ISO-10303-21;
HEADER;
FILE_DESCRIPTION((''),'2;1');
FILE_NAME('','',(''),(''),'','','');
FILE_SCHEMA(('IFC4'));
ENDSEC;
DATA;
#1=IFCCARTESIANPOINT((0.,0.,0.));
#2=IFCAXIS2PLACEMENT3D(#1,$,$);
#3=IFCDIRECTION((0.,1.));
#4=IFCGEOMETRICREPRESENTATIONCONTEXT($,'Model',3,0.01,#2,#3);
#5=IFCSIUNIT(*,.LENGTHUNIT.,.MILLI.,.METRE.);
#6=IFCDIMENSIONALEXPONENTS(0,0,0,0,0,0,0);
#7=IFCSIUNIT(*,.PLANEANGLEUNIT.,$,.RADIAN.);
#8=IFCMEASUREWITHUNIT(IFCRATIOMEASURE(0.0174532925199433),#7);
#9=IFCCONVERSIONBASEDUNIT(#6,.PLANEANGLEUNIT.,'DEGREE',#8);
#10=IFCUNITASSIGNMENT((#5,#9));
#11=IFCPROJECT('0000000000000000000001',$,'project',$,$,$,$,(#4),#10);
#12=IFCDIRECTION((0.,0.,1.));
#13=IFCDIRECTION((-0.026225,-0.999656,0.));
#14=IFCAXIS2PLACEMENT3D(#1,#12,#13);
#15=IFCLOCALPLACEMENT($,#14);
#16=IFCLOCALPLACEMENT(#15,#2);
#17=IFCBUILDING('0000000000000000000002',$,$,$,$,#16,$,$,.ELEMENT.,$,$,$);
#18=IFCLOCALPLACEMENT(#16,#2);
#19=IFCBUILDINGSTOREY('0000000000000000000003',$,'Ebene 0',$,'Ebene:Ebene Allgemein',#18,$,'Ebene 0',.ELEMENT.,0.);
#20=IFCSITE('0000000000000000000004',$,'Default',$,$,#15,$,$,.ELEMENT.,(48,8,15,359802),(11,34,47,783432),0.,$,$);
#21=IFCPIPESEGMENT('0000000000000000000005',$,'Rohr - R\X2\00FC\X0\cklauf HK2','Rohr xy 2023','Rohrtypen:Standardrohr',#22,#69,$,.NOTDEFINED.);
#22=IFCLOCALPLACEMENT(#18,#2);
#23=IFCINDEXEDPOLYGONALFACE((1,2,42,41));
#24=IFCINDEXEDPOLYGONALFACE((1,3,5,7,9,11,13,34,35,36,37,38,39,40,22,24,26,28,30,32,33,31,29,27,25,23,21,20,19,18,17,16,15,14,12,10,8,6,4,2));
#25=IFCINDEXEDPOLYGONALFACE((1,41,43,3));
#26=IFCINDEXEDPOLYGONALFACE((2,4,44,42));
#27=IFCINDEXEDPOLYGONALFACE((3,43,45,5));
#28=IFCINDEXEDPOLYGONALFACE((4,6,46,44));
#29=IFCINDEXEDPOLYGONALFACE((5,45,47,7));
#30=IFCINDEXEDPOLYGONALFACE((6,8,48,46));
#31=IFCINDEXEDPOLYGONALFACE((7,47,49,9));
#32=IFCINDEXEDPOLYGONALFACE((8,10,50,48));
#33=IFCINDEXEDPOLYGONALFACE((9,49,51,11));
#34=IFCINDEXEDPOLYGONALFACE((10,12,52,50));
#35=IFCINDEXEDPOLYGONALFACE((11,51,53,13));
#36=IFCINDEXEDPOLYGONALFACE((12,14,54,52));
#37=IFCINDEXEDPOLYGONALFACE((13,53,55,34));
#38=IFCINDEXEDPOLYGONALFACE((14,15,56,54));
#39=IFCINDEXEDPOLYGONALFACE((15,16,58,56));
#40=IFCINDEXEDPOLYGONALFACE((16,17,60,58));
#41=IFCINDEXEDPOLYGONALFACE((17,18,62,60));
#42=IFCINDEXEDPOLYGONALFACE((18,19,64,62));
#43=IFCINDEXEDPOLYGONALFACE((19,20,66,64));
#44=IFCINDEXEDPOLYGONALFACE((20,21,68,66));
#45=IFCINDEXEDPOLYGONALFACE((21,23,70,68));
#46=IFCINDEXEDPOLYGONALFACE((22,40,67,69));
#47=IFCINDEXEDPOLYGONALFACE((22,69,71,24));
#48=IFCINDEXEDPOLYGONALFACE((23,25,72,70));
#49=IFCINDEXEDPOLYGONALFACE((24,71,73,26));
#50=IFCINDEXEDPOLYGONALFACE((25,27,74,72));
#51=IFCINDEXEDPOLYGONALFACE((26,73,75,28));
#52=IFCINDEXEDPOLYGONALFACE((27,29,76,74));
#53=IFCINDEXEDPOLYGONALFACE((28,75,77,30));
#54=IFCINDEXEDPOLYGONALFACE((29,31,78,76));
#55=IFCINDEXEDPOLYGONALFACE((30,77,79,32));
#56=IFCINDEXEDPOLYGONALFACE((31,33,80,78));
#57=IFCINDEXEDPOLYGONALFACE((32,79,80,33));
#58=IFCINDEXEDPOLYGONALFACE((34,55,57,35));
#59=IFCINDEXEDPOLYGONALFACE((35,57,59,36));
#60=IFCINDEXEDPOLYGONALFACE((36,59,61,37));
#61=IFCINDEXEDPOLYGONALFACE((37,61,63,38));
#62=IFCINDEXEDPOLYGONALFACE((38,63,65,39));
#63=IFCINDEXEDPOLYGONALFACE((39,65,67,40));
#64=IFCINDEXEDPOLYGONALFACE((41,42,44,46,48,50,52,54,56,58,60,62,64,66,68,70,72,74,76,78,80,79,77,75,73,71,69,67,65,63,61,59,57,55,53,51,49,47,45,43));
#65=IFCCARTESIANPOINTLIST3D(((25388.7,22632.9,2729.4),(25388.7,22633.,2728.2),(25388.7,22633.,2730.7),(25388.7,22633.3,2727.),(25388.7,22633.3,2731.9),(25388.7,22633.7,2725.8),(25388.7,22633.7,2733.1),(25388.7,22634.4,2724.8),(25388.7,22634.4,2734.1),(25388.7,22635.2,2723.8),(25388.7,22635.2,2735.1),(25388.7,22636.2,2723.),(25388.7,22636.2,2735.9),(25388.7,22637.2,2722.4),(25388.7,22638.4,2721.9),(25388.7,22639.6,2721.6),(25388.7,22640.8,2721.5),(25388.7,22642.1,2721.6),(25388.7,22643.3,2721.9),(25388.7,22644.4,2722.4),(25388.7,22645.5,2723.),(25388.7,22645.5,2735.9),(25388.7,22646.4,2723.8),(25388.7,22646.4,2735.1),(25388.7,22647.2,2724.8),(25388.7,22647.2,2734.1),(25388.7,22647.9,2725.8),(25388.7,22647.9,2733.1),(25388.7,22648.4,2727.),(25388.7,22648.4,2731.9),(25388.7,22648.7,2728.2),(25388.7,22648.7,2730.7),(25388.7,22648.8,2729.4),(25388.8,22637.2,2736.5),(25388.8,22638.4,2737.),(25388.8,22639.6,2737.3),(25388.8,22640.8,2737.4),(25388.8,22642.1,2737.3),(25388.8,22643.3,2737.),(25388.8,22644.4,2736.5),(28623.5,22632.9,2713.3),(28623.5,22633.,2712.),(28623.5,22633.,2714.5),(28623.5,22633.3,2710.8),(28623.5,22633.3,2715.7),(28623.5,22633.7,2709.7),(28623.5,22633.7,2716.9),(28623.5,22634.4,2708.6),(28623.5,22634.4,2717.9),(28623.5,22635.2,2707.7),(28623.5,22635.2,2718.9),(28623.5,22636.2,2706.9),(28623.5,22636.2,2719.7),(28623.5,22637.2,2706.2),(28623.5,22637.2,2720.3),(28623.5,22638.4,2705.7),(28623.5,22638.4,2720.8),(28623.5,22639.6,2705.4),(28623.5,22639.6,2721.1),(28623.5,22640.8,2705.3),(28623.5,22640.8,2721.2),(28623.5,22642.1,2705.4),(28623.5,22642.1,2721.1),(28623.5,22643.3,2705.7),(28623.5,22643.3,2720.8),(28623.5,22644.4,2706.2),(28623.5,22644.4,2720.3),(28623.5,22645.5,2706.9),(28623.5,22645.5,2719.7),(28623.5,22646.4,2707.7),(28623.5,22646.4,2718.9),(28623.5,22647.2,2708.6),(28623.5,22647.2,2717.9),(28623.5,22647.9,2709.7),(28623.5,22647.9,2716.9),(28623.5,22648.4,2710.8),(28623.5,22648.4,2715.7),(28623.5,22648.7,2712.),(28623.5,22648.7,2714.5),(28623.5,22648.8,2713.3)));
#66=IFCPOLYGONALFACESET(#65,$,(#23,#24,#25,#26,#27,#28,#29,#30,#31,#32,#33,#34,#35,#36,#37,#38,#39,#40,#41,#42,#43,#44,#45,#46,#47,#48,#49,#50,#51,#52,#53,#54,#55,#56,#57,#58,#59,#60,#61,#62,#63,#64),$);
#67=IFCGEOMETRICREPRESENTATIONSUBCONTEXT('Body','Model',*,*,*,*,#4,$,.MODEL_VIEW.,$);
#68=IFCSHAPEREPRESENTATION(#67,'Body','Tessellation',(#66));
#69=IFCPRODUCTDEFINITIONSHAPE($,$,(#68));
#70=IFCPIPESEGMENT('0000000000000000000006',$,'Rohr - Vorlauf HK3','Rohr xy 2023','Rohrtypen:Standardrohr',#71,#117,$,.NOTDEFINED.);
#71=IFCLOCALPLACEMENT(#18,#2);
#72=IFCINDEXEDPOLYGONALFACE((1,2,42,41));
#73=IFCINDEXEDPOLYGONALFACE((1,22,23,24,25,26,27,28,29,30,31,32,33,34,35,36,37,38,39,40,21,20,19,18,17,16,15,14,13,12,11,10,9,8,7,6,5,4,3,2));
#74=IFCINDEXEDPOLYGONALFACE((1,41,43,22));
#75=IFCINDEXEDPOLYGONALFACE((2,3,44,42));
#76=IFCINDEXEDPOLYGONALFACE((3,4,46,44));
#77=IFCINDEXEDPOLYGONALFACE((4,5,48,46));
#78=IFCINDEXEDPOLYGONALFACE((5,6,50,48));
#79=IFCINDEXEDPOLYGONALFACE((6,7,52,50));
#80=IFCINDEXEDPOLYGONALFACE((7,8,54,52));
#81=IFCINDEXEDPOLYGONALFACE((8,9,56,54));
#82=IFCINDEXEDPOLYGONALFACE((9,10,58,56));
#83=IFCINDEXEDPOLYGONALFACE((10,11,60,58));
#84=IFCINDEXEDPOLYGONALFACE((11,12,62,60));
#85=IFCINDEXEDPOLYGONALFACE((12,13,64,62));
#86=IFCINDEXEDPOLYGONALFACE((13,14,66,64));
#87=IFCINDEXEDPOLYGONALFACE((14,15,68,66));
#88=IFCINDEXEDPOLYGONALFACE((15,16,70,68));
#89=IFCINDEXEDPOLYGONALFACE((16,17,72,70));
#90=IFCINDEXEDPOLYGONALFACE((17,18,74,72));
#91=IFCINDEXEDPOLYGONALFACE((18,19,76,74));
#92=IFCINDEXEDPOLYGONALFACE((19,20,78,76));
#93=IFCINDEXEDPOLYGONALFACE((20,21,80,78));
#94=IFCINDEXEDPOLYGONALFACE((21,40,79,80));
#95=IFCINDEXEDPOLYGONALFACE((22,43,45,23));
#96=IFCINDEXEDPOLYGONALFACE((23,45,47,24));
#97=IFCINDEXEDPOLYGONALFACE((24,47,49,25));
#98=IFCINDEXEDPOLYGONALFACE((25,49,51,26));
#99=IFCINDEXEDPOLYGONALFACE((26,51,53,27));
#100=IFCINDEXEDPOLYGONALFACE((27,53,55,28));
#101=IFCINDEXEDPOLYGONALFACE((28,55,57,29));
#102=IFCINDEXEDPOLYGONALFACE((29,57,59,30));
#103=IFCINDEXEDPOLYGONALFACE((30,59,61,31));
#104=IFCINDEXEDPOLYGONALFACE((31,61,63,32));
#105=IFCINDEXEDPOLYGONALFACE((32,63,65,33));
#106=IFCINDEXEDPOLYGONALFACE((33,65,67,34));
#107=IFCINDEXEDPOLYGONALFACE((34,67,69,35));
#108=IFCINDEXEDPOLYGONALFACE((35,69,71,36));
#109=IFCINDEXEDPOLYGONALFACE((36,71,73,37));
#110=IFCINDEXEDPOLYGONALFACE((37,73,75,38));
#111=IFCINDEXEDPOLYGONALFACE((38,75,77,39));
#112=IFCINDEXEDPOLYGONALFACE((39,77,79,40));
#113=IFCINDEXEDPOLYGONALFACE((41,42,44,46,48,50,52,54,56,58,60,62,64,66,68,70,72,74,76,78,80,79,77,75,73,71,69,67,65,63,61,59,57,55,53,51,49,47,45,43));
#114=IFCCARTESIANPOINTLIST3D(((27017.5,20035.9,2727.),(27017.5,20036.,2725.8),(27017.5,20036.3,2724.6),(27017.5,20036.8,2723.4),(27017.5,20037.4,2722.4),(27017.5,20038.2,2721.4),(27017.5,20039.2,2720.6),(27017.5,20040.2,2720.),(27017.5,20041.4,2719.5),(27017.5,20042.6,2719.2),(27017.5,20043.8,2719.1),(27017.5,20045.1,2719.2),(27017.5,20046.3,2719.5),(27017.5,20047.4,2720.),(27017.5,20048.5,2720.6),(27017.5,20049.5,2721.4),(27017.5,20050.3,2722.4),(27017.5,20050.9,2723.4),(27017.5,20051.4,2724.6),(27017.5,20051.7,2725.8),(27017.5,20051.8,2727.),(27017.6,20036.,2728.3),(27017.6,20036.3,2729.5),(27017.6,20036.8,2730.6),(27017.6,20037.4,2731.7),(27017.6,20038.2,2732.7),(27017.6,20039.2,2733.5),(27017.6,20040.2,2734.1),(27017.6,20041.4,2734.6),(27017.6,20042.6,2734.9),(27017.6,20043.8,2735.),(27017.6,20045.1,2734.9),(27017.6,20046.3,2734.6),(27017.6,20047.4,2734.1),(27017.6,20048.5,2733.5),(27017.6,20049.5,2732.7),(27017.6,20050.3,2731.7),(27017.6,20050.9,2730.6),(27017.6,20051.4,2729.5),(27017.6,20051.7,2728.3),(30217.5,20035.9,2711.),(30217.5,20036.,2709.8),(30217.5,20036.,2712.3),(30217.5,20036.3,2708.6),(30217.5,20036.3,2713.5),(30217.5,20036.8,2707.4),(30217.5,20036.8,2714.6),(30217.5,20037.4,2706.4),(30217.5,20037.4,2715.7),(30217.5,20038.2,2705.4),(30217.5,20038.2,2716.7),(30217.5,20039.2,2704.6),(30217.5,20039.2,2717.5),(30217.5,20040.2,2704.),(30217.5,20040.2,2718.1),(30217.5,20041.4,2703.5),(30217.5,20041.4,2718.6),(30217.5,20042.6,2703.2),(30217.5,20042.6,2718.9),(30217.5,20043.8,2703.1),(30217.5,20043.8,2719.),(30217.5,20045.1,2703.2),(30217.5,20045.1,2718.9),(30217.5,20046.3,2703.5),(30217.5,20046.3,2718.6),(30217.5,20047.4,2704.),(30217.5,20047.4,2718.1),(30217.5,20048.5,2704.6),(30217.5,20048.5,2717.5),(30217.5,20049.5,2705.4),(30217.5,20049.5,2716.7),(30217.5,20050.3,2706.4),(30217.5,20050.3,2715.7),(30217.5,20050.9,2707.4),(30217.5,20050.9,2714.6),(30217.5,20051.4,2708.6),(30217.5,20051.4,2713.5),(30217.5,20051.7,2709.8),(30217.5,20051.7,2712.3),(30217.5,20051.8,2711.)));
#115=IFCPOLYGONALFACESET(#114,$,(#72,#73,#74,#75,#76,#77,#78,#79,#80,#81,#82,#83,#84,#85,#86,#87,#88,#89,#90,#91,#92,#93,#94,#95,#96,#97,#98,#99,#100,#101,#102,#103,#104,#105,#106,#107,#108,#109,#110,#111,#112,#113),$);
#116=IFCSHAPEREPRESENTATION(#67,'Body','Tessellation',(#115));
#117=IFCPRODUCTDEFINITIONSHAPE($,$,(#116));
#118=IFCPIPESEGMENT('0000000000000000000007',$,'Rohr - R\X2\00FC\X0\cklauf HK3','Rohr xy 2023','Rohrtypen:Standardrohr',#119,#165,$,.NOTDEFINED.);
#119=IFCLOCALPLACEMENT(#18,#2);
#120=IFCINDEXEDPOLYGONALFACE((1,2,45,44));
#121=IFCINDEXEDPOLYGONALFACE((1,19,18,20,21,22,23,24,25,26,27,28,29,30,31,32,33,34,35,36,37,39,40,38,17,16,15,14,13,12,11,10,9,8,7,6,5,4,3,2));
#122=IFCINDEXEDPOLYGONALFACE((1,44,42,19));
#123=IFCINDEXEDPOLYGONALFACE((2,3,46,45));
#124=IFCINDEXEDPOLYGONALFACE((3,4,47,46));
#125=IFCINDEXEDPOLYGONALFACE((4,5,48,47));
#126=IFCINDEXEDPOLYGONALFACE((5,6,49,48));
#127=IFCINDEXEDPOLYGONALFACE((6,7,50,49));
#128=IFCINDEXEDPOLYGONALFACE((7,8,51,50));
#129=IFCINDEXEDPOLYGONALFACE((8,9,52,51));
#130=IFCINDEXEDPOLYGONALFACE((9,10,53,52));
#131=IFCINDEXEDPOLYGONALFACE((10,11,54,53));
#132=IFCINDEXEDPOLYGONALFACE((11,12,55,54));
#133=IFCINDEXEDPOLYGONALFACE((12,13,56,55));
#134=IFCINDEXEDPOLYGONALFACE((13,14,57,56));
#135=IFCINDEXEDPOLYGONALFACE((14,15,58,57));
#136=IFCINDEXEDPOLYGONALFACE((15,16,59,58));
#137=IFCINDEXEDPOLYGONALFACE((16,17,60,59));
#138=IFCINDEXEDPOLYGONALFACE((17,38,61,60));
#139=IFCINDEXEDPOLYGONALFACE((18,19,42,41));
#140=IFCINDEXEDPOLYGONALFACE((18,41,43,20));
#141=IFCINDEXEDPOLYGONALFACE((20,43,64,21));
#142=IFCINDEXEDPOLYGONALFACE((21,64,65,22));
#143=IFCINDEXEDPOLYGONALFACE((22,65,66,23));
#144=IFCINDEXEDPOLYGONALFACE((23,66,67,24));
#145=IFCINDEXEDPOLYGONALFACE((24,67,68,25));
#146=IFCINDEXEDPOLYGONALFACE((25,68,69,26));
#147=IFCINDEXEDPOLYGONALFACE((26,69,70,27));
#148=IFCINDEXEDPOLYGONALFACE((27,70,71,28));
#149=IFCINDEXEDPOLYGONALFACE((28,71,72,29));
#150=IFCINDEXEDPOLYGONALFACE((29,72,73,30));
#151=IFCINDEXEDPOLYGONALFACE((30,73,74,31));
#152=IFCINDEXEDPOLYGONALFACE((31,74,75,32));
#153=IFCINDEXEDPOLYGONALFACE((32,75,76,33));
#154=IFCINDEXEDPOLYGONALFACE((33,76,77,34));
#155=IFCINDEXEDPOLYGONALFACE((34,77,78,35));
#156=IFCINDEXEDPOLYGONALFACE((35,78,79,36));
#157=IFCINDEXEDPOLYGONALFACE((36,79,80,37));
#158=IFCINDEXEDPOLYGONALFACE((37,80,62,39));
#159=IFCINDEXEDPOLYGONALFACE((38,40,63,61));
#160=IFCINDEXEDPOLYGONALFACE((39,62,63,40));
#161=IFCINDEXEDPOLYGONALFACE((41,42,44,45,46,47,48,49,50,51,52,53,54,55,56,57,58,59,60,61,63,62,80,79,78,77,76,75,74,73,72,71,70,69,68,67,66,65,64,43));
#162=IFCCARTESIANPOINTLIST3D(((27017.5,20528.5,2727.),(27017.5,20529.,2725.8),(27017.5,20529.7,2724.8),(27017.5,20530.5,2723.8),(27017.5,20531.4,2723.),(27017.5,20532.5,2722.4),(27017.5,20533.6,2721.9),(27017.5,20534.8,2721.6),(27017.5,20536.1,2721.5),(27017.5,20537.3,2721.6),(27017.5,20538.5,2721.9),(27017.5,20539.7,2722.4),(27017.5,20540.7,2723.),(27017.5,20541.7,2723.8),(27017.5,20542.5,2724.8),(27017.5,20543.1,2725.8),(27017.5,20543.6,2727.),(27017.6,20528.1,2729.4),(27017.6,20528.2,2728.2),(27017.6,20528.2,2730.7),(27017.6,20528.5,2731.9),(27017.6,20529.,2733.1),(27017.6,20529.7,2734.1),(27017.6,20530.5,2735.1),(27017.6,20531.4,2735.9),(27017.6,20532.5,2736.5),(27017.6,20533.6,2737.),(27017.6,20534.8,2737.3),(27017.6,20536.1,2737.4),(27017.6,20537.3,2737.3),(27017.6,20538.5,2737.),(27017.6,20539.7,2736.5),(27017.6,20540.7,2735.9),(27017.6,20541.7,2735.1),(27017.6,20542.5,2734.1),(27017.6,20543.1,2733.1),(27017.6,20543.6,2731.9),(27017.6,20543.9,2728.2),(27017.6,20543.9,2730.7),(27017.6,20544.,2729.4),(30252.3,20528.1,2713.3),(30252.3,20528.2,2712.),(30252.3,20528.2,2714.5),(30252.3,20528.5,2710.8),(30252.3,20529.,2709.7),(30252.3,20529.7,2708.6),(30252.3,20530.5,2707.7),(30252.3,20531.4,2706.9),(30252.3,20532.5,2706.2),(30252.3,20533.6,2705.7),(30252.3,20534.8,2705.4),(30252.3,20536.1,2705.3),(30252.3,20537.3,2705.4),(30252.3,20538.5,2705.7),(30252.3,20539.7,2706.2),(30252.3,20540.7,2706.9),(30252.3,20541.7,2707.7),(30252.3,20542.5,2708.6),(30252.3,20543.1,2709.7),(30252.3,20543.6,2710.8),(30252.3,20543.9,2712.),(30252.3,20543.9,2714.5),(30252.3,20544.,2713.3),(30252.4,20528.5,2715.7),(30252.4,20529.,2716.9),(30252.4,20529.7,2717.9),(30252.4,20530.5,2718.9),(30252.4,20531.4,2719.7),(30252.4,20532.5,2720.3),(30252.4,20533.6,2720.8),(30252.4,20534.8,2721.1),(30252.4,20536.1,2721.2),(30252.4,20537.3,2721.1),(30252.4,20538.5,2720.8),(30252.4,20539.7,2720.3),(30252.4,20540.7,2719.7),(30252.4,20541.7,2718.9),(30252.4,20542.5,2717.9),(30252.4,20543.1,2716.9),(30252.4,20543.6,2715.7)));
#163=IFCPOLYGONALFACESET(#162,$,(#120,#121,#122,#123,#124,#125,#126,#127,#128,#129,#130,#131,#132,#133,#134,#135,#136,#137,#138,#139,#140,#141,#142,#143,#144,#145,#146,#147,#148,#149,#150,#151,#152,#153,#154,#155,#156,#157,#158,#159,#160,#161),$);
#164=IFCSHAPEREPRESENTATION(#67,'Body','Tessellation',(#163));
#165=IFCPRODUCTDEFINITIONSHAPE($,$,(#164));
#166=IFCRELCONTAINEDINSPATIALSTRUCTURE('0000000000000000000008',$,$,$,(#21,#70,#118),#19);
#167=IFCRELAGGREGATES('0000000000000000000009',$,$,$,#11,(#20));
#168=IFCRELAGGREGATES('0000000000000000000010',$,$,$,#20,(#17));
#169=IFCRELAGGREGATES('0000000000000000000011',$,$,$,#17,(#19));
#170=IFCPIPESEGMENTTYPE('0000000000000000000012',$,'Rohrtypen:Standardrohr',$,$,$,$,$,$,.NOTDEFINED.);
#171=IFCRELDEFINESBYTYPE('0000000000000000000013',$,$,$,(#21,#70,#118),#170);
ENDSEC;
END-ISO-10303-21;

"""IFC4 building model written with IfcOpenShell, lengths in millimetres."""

from ifc_helpers import new_model, entity, si_unit, converted_unit, direction, frame, origin, place, context, subcontext, project, spatial, indexed_curve, outline, extrude, type_object, element, save


model = new_model("IFC4")

# Units and contexts
model_context = context("Model", 3, precision=0.01, world=origin(), true_north=direction((0.0, 1.0)))
body_context = subcontext(model_context, "Body", "Model", "MODEL_VIEW")
ifc_project = project(units=[si_unit("LENGTHUNIT", "METRE", prefix="MILLI"), converted_unit("PLANEANGLEUNIT", "DEGREE", entity("IfcRatioMeasure", 0.0174532925199433), si_unit("PLANEANGLEUNIT", "RADIAN"), dimensions=[0, 0, 0, 0, 0, 0, 0])], contexts=[model_context])

# Site, building, storey
site_placement = place(None, frame((0.0, 0.0, 0.0), z_axis=(0.0, 0.0, 1.0), x_axis=(-0.026225, -0.999656, 0.0)))
site = spatial("IfcSite", under=ifc_project, at=site_placement, Name="Default", CompositionType="ELEMENT", RefLatitude=(48, 8, 15, 359802), RefLongitude=(11, 34, 47, 783432), RefElevation=0.0)
building_placement = place(site_placement, origin())
building = spatial("IfcBuilding", under=site, at=building_placement, CompositionType="ELEMENT")
storey_placement = place(building_placement, origin())
storey = spatial("IfcBuildingStorey", under=building, at=storey_placement, Name="Ebene 0", ObjectType="Ebene:Ebene Allgemein", LongName="Ebene 0", CompositionType="ELEMENT", Elevation=0.0)

# Pipe segments
pipe_segment_type = type_object("IfcPipeSegmentType", Name="Rohrtypen:Standardrohr", PredefinedType="NOTDEFINED")
pipe_segment_1_placement = place(storey_placement, origin())
element("IfcPipeSegment", 1, at=pipe_segment_1_placement, inside=storey, type_object=pipe_segment_type, Name="Rohr - Rücklauf HK2", Description="Rohr xy 2023", ObjectType="Rohrtypen:Standardrohr", PredefinedType="NOTDEFINED", context=body_context, shape_type="SweptSolid", body=[
    extrude(outline(indexed_curve([(7.9, 0.0), (7.8, 1.2), (7.6, 2.5), (7.1, 3.6), (6.4, 4.7), (5.6, 5.6), (4.7, 6.4), (3.6, 7.1), (2.5, 7.6), (1.2, 7.8), (0.0, 7.9), (-1.2, 7.8), (-2.5, 7.6), (-3.6, 7.1), (-4.7, 6.4), (-5.6, 5.6), (-6.4, 4.7), (-7.1, 3.6), (-7.6, 2.5), (-7.8, 1.2), (-7.9, 0.0), (-7.8, -1.2), (-7.6, -2.5), (-7.1, -3.6), (-6.4, -4.7), (-5.6, -5.6), (-4.7, -6.4), (-3.6, -7.1), (-2.5, -7.6), (-1.2, -7.8), (0.0, -7.9), (1.2, -7.8), (2.5, -7.6), (3.6, -7.1), (4.7, -6.4), (5.6, -5.6), (6.4, -4.7), (7.1, -3.6), (7.6, -2.5), (7.8, -1.2), (7.9, 0.0)], self_intersect=False)), frame((28623.5, 22640.8, 2713.3), z_axis=(-0.999988, 0.0, 0.005), x_axis=(0.0, 1.0, 0.0)), (0.0, 0.0, 1.0), 3234.8),
])
pipe_segment_2_placement = place(storey_placement, origin())
element("IfcPipeSegment", 2, at=pipe_segment_2_placement, inside=storey, type_object=pipe_segment_type, Name="Rohr - Vorlauf HK3", Description="Rohr xy 2023", ObjectType="Rohrtypen:Standardrohr", PredefinedType="NOTDEFINED", context=body_context, shape_type="SweptSolid", body=[
    extrude(outline(indexed_curve([(7.9, 0.0), (7.8, 1.2), (7.6, 2.5), (7.1, 3.6), (6.4, 4.7), (5.6, 5.6), (4.7, 6.4), (3.6, 7.1), (2.5, 7.6), (1.2, 7.8), (0.0, 7.9), (-1.2, 7.8), (-2.5, 7.6), (-3.6, 7.1), (-4.7, 6.4), (-5.6, 5.6), (-6.4, 4.7), (-7.1, 3.6), (-7.6, 2.5), (-7.8, 1.2), (-7.9, 0.0), (-7.8, -1.2), (-7.6, -2.5), (-7.1, -3.6), (-6.4, -4.7), (-5.6, -5.6), (-4.7, -6.4), (-3.6, -7.1), (-2.5, -7.6), (-1.2, -7.8), (0.0, -7.9), (1.2, -7.8), (2.5, -7.6), (3.6, -7.1), (4.7, -6.4), (5.6, -5.6), (6.4, -4.7), (7.1, -3.6), (7.6, -2.5), (7.8, -1.2), (7.9, 0.0)], self_intersect=False)), frame((30217.5, 20043.8, 2711.0), z_axis=(-0.999988, 0.0, 0.005), x_axis=(0.0, 1.0, 0.0)), (0.0, 0.0, 1.0), 3200.0),
])
pipe_segment_3_placement = place(storey_placement, origin())
element("IfcPipeSegment", 3, at=pipe_segment_3_placement, inside=storey, type_object=pipe_segment_type, Name="Rohr - Rücklauf HK3", Description="Rohr xy 2023", ObjectType="Rohrtypen:Standardrohr", PredefinedType="NOTDEFINED", context=body_context, shape_type="SweptSolid", body=[
    extrude(outline(indexed_curve([(7.9, 0.0), (7.8, 1.2), (7.6, 2.5), (7.1, 3.6), (6.4, 4.7), (5.6, 5.6), (4.7, 6.4), (3.6, 7.1), (2.5, 7.6), (1.2, 7.8), (0.0, 7.9), (-1.2, 7.8), (-2.5, 7.6), (-3.6, 7.1), (-4.7, 6.4), (-5.6, 5.6), (-6.4, 4.7), (-7.1, 3.6), (-7.6, 2.5), (-7.8, 1.2), (-7.9, 0.0), (-7.8, -1.2), (-7.6, -2.5), (-7.1, -3.6), (-6.4, -4.7), (-5.6, -5.6), (-4.7, -6.4), (-3.6, -7.1), (-2.5, -7.6), (-1.2, -7.8), (0.0, -7.9), (1.2, -7.8), (2.5, -7.6), (3.6, -7.1), (4.7, -6.4), (5.6, -5.6), (6.4, -4.7), (7.1, -3.6), (7.6, -2.5), (7.8, -1.2), (7.9, 0.0)], self_intersect=False)), frame((30252.3, 20536.1, 2713.3), z_axis=(-0.999988, 0.0, 0.005), x_axis=(0.0, 1.0, 0.0)), (0.0, 0.0, 1.0), 3234.8),
])

save(model, "model.ifc")
